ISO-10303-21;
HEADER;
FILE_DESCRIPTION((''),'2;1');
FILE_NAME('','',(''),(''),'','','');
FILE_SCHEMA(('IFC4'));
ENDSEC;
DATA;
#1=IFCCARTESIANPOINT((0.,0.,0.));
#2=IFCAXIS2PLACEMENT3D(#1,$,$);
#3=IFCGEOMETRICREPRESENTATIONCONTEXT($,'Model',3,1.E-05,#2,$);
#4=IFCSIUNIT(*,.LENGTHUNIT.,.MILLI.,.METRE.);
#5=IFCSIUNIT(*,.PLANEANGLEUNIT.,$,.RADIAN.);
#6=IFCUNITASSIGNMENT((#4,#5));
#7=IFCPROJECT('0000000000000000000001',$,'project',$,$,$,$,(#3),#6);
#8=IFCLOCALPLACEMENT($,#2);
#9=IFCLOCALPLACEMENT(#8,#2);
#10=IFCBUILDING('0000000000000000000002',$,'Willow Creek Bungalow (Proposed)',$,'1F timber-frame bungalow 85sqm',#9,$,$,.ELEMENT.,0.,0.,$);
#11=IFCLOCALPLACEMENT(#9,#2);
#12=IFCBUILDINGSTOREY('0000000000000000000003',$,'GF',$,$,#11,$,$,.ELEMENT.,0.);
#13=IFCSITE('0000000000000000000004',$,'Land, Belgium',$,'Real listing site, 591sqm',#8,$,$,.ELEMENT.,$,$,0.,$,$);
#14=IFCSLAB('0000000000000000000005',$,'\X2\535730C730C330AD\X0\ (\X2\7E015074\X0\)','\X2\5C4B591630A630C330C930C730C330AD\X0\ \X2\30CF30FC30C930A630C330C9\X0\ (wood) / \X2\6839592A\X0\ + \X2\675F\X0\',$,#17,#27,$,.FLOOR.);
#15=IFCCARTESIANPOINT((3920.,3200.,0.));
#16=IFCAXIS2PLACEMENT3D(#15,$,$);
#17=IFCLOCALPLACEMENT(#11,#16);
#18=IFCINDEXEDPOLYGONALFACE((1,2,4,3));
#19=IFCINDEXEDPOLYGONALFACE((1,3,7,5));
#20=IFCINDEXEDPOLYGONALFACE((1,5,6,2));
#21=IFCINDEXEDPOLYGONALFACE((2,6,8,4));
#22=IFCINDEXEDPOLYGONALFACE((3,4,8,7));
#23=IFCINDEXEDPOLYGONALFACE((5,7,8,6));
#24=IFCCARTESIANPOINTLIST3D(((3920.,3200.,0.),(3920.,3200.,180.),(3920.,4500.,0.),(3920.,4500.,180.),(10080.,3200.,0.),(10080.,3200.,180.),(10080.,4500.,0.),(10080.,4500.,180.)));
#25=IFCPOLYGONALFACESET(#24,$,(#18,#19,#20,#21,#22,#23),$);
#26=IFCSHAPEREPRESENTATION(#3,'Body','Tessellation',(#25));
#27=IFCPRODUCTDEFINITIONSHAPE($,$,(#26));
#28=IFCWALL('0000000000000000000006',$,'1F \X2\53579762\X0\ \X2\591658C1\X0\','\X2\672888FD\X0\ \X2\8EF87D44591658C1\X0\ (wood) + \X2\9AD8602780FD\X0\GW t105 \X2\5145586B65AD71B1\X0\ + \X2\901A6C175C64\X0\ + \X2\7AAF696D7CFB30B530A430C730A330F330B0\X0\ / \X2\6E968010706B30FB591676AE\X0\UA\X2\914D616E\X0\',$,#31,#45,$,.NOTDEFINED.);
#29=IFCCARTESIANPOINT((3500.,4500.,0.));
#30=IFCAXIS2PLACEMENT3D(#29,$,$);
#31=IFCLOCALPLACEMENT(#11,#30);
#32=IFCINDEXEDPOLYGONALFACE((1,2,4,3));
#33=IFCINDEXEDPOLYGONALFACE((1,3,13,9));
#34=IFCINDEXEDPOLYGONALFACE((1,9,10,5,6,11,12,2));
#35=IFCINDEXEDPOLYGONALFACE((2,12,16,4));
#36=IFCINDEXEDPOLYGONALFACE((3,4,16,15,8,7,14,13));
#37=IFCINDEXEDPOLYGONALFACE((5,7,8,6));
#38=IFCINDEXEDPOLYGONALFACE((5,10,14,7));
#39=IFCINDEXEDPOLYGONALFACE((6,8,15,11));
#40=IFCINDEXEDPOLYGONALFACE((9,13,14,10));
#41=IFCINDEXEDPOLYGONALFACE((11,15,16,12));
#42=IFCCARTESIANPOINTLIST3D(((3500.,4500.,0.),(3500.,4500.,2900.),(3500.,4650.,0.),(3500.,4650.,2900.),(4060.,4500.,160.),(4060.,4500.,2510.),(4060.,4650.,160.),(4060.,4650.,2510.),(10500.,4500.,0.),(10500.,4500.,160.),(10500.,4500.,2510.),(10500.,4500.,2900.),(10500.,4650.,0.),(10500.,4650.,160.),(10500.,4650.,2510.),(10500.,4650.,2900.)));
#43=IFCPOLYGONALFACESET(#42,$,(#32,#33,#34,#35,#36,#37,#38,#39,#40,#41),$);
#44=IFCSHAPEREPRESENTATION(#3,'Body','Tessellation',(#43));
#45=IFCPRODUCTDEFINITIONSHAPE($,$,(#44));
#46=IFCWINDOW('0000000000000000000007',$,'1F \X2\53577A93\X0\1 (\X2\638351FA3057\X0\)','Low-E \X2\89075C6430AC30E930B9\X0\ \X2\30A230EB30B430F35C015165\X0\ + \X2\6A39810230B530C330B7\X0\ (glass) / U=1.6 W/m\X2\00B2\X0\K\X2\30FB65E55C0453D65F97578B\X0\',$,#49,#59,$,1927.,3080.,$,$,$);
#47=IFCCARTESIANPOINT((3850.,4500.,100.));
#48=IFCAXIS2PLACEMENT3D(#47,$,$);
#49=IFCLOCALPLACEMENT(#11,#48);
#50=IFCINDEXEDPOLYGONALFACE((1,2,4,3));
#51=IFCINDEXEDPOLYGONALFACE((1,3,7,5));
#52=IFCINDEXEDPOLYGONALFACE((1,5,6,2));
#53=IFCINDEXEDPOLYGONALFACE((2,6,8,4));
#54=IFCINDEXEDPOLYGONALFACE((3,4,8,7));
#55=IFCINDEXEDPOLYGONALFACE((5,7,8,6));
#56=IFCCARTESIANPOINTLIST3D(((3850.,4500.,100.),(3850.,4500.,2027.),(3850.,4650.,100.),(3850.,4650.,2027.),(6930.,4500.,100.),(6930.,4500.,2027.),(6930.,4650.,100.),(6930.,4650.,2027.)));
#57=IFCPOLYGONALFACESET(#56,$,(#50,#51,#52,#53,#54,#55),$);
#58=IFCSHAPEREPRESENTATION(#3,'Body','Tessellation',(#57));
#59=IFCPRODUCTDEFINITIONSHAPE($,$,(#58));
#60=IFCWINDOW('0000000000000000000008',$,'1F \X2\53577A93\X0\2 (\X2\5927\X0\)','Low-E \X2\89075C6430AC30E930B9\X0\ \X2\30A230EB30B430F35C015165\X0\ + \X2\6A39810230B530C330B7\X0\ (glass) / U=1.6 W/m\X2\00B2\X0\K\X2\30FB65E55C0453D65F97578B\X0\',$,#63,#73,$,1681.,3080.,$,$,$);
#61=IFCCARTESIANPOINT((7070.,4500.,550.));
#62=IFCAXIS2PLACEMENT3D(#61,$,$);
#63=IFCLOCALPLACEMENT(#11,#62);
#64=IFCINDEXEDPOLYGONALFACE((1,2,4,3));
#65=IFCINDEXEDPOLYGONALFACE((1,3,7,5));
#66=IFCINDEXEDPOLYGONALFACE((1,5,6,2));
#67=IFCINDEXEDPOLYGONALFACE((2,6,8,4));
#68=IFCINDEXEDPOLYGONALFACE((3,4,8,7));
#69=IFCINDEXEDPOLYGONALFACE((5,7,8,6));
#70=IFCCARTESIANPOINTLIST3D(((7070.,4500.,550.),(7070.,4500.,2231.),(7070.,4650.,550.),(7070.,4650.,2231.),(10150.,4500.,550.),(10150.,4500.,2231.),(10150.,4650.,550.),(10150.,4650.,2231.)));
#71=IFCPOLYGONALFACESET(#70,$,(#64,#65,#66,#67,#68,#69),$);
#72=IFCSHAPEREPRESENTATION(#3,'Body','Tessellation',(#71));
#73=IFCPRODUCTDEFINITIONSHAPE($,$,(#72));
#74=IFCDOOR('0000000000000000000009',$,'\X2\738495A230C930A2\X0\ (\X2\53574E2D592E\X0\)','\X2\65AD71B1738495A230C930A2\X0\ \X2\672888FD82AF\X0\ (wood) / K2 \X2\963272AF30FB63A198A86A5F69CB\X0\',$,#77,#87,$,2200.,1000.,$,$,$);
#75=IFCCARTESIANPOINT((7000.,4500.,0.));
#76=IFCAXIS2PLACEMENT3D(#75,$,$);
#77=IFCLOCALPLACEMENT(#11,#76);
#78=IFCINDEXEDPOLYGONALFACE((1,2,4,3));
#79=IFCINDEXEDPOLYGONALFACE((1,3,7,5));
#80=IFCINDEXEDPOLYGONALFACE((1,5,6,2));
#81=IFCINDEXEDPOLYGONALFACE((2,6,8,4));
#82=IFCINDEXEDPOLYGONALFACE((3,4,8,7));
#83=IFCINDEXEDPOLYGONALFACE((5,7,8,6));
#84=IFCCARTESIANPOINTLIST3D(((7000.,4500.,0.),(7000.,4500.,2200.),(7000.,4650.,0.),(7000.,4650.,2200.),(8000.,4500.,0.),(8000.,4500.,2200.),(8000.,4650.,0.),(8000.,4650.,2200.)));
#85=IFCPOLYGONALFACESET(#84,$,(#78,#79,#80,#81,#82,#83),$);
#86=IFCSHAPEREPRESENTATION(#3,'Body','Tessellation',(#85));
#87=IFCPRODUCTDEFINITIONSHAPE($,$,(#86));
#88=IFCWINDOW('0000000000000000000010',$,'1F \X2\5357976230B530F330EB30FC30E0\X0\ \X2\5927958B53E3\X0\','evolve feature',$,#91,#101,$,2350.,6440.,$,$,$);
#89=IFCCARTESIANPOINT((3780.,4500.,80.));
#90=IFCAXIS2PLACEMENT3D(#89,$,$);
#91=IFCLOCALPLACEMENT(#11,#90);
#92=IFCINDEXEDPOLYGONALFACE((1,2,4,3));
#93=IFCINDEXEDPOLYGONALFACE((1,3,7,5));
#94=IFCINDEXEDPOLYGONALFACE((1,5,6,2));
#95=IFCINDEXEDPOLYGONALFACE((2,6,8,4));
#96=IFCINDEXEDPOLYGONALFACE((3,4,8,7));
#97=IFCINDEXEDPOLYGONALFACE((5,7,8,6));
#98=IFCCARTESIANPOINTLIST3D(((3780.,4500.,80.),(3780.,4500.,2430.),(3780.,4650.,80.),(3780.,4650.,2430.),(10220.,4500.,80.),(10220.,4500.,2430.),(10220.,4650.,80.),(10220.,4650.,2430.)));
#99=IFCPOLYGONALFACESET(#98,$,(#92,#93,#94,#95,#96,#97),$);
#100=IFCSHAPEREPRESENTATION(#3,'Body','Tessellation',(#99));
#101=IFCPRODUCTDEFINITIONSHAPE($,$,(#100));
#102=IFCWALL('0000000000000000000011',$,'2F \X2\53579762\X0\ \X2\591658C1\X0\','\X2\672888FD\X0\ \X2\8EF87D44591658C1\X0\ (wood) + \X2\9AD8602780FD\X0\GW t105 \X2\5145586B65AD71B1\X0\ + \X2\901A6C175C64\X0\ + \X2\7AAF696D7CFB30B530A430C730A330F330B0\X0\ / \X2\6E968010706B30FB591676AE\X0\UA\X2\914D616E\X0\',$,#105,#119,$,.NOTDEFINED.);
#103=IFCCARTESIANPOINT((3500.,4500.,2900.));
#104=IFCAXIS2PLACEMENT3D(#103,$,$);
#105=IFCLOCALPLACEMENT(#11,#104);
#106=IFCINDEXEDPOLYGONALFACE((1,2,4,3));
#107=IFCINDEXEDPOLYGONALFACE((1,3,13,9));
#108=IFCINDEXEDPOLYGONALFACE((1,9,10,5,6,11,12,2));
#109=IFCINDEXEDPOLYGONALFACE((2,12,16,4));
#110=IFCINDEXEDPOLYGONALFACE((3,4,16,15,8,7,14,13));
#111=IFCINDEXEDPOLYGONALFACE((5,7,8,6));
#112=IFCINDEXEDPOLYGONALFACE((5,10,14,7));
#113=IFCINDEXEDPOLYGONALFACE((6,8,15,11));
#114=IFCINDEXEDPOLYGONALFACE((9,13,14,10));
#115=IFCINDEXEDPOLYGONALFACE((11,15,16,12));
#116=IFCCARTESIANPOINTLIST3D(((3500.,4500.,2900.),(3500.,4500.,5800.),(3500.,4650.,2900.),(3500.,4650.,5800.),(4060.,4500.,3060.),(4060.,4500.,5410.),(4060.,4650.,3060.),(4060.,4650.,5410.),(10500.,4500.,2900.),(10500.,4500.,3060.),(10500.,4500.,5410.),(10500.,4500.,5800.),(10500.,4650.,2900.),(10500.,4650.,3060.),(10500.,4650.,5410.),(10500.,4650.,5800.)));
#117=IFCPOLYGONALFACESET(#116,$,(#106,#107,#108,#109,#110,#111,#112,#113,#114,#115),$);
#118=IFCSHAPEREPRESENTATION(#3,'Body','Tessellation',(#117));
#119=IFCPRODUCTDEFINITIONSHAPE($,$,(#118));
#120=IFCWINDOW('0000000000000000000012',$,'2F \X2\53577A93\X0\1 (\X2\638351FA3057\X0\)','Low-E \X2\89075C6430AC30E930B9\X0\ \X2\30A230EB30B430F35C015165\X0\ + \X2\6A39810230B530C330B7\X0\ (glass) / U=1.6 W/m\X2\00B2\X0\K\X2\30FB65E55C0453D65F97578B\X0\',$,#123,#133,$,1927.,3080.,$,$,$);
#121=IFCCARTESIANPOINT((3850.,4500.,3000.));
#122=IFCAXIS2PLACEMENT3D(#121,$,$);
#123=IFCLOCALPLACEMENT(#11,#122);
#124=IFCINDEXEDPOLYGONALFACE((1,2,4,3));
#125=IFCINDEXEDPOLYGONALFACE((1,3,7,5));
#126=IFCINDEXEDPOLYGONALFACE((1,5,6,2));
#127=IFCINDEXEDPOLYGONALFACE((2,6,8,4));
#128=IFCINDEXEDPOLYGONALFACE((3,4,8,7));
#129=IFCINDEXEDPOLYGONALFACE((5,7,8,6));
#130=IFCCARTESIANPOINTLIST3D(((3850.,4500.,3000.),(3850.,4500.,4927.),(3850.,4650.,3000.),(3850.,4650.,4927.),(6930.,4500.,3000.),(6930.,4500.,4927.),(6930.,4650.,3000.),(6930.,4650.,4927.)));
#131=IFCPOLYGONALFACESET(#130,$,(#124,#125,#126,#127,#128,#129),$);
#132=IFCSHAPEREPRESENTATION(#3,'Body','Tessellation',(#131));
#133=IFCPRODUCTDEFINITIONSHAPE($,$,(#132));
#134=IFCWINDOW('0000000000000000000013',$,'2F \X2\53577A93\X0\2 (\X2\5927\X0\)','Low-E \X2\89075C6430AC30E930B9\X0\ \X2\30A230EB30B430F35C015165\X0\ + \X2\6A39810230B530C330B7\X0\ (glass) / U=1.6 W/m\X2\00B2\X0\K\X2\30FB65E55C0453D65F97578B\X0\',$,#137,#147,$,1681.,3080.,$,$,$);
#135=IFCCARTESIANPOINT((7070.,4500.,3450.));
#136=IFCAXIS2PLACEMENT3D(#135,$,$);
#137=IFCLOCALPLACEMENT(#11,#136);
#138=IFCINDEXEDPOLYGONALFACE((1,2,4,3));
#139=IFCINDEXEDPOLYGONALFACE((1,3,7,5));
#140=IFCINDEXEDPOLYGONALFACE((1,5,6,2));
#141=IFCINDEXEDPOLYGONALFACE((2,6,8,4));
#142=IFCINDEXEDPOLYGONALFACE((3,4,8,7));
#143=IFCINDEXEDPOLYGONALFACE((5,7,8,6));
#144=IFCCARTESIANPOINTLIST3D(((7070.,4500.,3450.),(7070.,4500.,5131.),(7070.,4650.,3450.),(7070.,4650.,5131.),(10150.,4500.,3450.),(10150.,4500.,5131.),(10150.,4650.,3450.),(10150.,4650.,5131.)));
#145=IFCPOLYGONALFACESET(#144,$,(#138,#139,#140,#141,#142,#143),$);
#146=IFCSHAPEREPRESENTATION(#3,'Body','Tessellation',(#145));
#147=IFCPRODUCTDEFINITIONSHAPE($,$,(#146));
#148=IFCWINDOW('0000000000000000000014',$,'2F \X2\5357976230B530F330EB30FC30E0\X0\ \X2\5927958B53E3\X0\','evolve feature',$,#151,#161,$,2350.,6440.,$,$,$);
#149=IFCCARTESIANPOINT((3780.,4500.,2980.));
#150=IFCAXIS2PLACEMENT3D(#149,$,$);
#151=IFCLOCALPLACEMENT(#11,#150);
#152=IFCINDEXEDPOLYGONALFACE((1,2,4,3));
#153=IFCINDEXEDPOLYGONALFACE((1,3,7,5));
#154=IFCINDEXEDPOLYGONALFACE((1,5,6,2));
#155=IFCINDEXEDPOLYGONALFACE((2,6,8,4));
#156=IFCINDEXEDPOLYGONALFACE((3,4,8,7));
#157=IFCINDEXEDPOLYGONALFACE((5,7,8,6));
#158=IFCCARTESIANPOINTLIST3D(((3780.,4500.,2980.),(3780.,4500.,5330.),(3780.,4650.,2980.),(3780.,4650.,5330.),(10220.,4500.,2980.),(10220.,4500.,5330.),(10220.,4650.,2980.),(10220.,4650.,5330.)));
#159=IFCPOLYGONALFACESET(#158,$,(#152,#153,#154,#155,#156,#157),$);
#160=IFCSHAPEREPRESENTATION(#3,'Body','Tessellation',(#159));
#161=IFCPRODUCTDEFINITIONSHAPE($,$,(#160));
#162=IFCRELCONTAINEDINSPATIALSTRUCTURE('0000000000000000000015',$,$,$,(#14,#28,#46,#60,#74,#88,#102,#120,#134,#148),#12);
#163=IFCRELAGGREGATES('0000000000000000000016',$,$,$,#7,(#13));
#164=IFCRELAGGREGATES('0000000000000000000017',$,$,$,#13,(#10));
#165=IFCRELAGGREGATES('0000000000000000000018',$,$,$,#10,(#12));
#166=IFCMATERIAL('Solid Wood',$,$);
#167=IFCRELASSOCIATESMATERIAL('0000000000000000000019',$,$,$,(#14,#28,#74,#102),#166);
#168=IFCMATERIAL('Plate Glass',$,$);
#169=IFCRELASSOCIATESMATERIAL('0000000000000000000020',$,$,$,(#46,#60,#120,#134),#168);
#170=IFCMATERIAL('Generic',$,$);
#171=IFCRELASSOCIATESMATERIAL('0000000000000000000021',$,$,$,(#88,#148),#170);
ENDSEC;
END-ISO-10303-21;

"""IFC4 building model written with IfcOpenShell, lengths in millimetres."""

from ifc_helpers import new_model, si_unit, frame, frame_2d, origin, place, context, project, spatial, rectangle, extrude, material, element, fill, save


model = new_model("IFC4")

# Units and contexts
model_context = context("Model", 3, precision=1e-05, world=origin())
ifc_project = project(units=[si_unit("LENGTHUNIT", "METRE", prefix="MILLI"), si_unit("PLANEANGLEUNIT", "RADIAN")], contexts=[model_context])

# Site, building, storey
site_placement = place(None, origin())
site = spatial("IfcSite", under=ifc_project, at=site_placement, Name="Land, Belgium", ObjectType="Real listing site, 591sqm", CompositionType="ELEMENT", RefElevation=0.0)
building_placement = place(site_placement, origin())
building = spatial("IfcBuilding", under=site, at=building_placement, Name="Willow Creek Bungalow (Proposed)", ObjectType="1F timber-frame bungalow 85sqm", CompositionType="ELEMENT", ElevationOfRefHeight=0.0, ElevationOfTerrain=0.0)
storey_placement = place(building_placement, origin())
storey = spatial("IfcBuildingStorey", under=building, at=storey_placement, Name="GF", CompositionType="ELEMENT", Elevation=0.0)

# Slab
ifc_material_1 = material(Name="Solid Wood")
slab_1_placement = place(storey_placement, frame((3920.0, 3200.0, 0.0)))
element("IfcSlab", 1, at=slab_1_placement, inside=storey, material=ifc_material_1, Name="南デッキ (縁側)", Description="屋外ウッドデッキ ハードウッド (wood) / 根太 + 束", PredefinedType="FLOOR", context=model_context, shape_type="SweptSolid", body=[
    extrude(rectangle(XDim=6160.0, YDim=1300.0, at=frame_2d((3080.0, 650.0))), frame((3920.0, 3200.0, 0.0)), (0.0, 0.0, 1.0), 180.0),
])
ifc_material_2 = material(Name="Generic")

# Wall, openings, windows, door
wall_1_placement = place(storey_placement, frame((3500.0, 4500.0, 0.0)))
wall_1 = element("IfcWall", 2, at=wall_1_placement, inside=storey, material=ifc_material_1, Name="1F 南面 外壁", Description="木製 軸組外壁 (wood) + 高性能GW t105 充填断熱 + 通気層 + 窯業系サイディング / 準耐火・外皮UA配慮", PredefinedType="NOTDEFINED", context=model_context, shape_type="SweptSolid", body=[
    extrude(rectangle(XDim=7000.0, YDim=150.0, at=frame_2d((3500.0, 75.0))), frame((3500.0, 4500.0, 0.0)), (0.0, 0.0, 1.0), 2900.0),
])
opening_1_placement = place(storey_placement, frame((3850.0, 4500.0, 100.0)))
opening_1 = element("IfcOpeningElement", 3, at=opening_1_placement, cuts=wall_1, PredefinedType="NOTDEFINED", context=model_context, shape_type="SweptSolid", body=[
    extrude(rectangle(XDim=3080.0, YDim=150.0, at=frame_2d((1540.0, 75.0))), frame((3850.0, 4500.0, 100.0)), (0.0, 0.0, 1.0), 1927.0),
])
opening_2_placement = place(storey_placement, frame((7070.0, 4500.0, 550.0)))
opening_2 = element("IfcOpeningElement", 4, at=opening_2_placement, cuts=wall_1, PredefinedType="NOTDEFINED", context=model_context, shape_type="SweptSolid", body=[
    extrude(rectangle(XDim=3080.0, YDim=150.0, at=frame_2d((1540.0, 75.0))), frame((7070.0, 4500.0, 550.0)), (0.0, 0.0, 1.0), 1681.0),
])
opening_3_placement = place(storey_placement, frame((7000.0, 4500.0, 0.0)))
opening_3 = element("IfcOpeningElement", 5, at=opening_3_placement, cuts=wall_1, PredefinedType="NOTDEFINED", context=model_context, shape_type="SweptSolid", body=[
    extrude(rectangle(XDim=1000.0, YDim=150.0, at=frame_2d((500.0, 75.0))), frame((7000.0, 4500.0, 0.0)), (0.0, 0.0, 1.0), 2200.0),
])
opening_4_placement = place(storey_placement, frame((3780.0, 4500.0, 80.0)))
opening_4 = element("IfcOpeningElement", 6, at=opening_4_placement, cuts=wall_1, PredefinedType="NOTDEFINED", context=model_context, shape_type="SweptSolid", body=[
    extrude(rectangle(XDim=6440.0, YDim=150.0, at=frame_2d((3220.0, 75.0))), frame((3780.0, 4500.0, 80.0)), (0.0, 0.0, 1.0), 2350.0),
])
ifc_material_3 = material(Name="Plate Glass")
window_1_placement = place(storey_placement, frame((3850.0, 4500.0, 100.0)))
window_1 = element("IfcWindow", 7, at=window_1_placement, inside=storey, material=ifc_material_3, Name="1F 南窓1 (掃出し)", Description="Low-E 複層ガラス アルゴン封入 + 樹脂サッシ (glass) / U=1.6 W/m²K・日射取得型", OverallHeight=1927.0, OverallWidth=3080.0, context=model_context, shape_type="SweptSolid", body=[
    extrude(rectangle(XDim=3080.0, YDim=150.0, at=frame_2d((1540.0, 75.0))), frame((3850.0, 4500.0, 100.0)), (0.0, 0.0, 1.0), 1927.0),
])
fill(opening_1, window_1)
window_2_placement = place(storey_placement, frame((7070.0, 4500.0, 550.0)))
window_2 = element("IfcWindow", 8, at=window_2_placement, inside=storey, material=ifc_material_3, Name="1F 南窓2 (大)", Description="Low-E 複層ガラス アルゴン封入 + 樹脂サッシ (glass) / U=1.6 W/m²K・日射取得型", OverallHeight=1681.0, OverallWidth=3080.0, context=model_context, shape_type="SweptSolid", body=[
    extrude(rectangle(XDim=3080.0, YDim=150.0, at=frame_2d((1540.0, 75.0))), frame((7070.0, 4500.0, 550.0)), (0.0, 0.0, 1.0), 1681.0),
])
fill(opening_2, window_2)
door_placement = place(storey_placement, frame((7000.0, 4500.0, 0.0)))
door = element("IfcDoor", 9, at=door_placement, inside=storey, material=ifc_material_1, Name="玄関ドア (南中央)", Description="断熱玄関ドア 木製芯 (wood) / K2 防犯・採風機構", OverallHeight=2200.0, OverallWidth=1000.0, context=model_context, shape_type="SweptSolid", body=[
    extrude(rectangle(XDim=1000.0, YDim=150.0, at=frame_2d((500.0, 75.0))), frame((7000.0, 4500.0, 0.0)), (0.0, 0.0, 1.0), 2200.0),
])
fill(opening_3, door)
window_3_placement = place(storey_placement, frame((3780.0, 4500.0, 80.0)))
window_3 = element("IfcWindow", 10, at=window_3_placement, inside=storey, material=ifc_material_2, Name="1F 南面サンルーム 大開口", Description="evolve feature", OverallHeight=2350.0, OverallWidth=6440.0, context=model_context, shape_type="SweptSolid", body=[
    extrude(rectangle(XDim=6440.0, YDim=150.0, at=frame_2d((3220.0, 75.0))), frame((3780.0, 4500.0, 80.0)), (0.0, 0.0, 1.0), 2350.0),
])
fill(opening_4, window_3)

# Wall, openings, windows
wall_2_placement = place(storey_placement, frame((3500.0, 4500.0, 2900.0)))
wall_2 = element("IfcWall", 11, at=wall_2_placement, inside=storey, material=ifc_material_1, Name="2F 南面 外壁", Description="木製 軸組外壁 (wood) + 高性能GW t105 充填断熱 + 通気層 + 窯業系サイディング / 準耐火・外皮UA配慮", PredefinedType="NOTDEFINED", context=model_context, shape_type="SweptSolid", body=[
    extrude(rectangle(XDim=7000.0, YDim=150.0, at=frame_2d((3500.0, 75.0))), frame((3500.0, 4500.0, 2900.0)), (0.0, 0.0, 1.0), 2900.0),
])
opening_5_placement = place(storey_placement, frame((3850.0, 4500.0, 3000.0)))
opening_5 = element("IfcOpeningElement", 12, at=opening_5_placement, cuts=wall_2, PredefinedType="NOTDEFINED", context=model_context, shape_type="SweptSolid", body=[
    extrude(rectangle(XDim=3080.0, YDim=150.0, at=frame_2d((1540.0, 75.0))), frame((3850.0, 4500.0, 3000.0)), (0.0, 0.0, 1.0), 1927.0),
])
opening_6_placement = place(storey_placement, frame((7070.0, 4500.0, 3450.0)))
opening_6 = element("IfcOpeningElement", 13, at=opening_6_placement, cuts=wall_2, PredefinedType="NOTDEFINED", context=model_context, shape_type="SweptSolid", body=[
    extrude(rectangle(XDim=3080.0, YDim=150.0, at=frame_2d((1540.0, 75.0))), frame((7070.0, 4500.0, 3450.0)), (0.0, 0.0, 1.0), 1681.0),
])
opening_7_placement = place(storey_placement, frame((3780.0, 4500.0, 2980.0)))
opening_7 = element("IfcOpeningElement", 14, at=opening_7_placement, cuts=wall_2, PredefinedType="NOTDEFINED", context=model_context, shape_type="SweptSolid", body=[
    extrude(rectangle(XDim=6440.0, YDim=150.0, at=frame_2d((3220.0, 75.0))), frame((3780.0, 4500.0, 2980.0)), (0.0, 0.0, 1.0), 2350.0),
])
window_4_placement = place(storey_placement, frame((3850.0, 4500.0, 3000.0)))
window_4 = element("IfcWindow", 15, at=window_4_placement, inside=storey, material=ifc_material_3, Name="2F 南窓1 (掃出し)", Description="Low-E 複層ガラス アルゴン封入 + 樹脂サッシ (glass) / U=1.6 W/m²K・日射取得型", OverallHeight=1927.0, OverallWidth=3080.0, context=model_context, shape_type="SweptSolid", body=[
    extrude(rectangle(XDim=3080.0, YDim=150.0, at=frame_2d((1540.0, 75.0))), frame((3850.0, 4500.0, 3000.0)), (0.0, 0.0, 1.0), 1927.0),
])
fill(opening_5, window_4)
window_5_placement = place(storey_placement, frame((7070.0, 4500.0, 3450.0)))
window_5 = element("IfcWindow", 16, at=window_5_placement, inside=storey, material=ifc_material_3, Name="2F 南窓2 (大)", Description="Low-E 複層ガラス アルゴン封入 + 樹脂サッシ (glass) / U=1.6 W/m²K・日射取得型", OverallHeight=1681.0, OverallWidth=3080.0, context=model_context, shape_type="SweptSolid", body=[
    extrude(rectangle(XDim=3080.0, YDim=150.0, at=frame_2d((1540.0, 75.0))), frame((7070.0, 4500.0, 3450.0)), (0.0, 0.0, 1.0), 1681.0),
])
fill(opening_6, window_5)
window_6_placement = place(storey_placement, frame((3780.0, 4500.0, 2980.0)))
window_6 = element("IfcWindow", 17, at=window_6_placement, inside=storey, material=ifc_material_2, Name="2F 南面サンルーム 大開口", Description="evolve feature", OverallHeight=2350.0, OverallWidth=6440.0, context=model_context, shape_type="SweptSolid", body=[
    extrude(rectangle(XDim=6440.0, YDim=150.0, at=frame_2d((3220.0, 75.0))), frame((3780.0, 4500.0, 2980.0)), (0.0, 0.0, 1.0), 2350.0),
])
fill(opening_7, window_6)

save(model, "model.ifc")
